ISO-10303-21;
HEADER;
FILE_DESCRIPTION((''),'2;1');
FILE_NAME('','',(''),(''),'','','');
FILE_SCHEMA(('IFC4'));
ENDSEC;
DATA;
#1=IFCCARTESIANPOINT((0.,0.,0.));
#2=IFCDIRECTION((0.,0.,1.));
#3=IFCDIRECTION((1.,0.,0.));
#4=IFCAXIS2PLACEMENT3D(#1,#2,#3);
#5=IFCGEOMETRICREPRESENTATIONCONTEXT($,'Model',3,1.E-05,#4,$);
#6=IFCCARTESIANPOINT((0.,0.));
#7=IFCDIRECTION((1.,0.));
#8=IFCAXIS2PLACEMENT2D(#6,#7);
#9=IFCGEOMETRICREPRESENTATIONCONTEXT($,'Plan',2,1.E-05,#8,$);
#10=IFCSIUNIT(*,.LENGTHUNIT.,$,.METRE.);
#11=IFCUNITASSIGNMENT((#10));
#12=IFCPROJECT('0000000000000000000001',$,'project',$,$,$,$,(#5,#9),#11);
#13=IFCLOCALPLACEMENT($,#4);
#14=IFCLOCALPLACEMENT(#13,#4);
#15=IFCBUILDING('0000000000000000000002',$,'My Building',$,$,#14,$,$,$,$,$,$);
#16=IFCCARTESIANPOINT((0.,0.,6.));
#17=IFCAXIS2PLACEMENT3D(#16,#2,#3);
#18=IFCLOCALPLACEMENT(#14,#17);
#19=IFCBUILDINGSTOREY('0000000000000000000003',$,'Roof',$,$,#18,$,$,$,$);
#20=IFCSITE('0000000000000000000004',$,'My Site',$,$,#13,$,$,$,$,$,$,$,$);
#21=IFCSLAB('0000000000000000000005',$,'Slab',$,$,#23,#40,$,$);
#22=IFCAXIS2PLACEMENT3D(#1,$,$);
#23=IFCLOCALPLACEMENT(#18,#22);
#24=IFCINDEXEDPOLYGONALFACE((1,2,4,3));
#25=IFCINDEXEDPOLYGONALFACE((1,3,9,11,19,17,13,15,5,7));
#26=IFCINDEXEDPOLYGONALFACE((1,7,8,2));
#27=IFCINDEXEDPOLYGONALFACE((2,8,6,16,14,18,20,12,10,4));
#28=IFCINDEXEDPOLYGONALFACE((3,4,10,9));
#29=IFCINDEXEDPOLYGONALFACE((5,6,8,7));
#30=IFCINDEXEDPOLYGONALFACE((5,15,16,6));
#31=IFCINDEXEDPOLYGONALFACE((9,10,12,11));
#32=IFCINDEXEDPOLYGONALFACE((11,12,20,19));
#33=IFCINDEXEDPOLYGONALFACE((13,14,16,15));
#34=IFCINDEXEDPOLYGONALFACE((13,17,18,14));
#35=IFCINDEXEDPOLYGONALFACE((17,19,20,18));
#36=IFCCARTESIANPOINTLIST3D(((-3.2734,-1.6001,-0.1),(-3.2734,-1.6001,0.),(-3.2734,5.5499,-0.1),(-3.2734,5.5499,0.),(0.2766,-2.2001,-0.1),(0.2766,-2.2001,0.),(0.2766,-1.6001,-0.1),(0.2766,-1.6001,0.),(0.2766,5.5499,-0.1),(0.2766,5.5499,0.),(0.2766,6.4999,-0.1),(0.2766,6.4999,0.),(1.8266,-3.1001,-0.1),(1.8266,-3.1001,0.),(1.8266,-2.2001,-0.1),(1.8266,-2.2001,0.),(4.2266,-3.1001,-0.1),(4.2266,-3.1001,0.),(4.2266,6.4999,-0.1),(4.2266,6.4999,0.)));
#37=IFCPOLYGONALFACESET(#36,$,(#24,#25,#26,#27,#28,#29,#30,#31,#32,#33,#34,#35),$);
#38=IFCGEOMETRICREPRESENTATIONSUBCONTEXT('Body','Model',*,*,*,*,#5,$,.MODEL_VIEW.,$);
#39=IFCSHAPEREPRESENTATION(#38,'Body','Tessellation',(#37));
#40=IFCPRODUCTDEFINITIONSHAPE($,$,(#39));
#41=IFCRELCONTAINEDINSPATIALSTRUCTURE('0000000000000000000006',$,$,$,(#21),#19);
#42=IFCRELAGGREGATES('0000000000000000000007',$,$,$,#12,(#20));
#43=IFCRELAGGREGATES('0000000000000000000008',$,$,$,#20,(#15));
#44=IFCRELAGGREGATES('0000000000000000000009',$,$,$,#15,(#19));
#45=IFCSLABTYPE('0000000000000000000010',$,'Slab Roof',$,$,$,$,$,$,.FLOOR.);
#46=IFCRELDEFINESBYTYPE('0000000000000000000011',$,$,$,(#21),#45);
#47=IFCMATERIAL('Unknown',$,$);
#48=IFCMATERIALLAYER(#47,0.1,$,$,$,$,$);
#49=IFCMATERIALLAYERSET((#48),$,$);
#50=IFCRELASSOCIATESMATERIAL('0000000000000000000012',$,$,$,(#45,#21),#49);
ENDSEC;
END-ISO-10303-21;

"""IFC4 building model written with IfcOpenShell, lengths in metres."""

from ifc_helpers import new_model, si_unit, frame, origin_with_axes, origin_2d_with_axis, place, context, subcontext, project, spatial, indexed_curve, outline, extrude, material, layer, layer_set, layer_usage, type_object, element, save


model = new_model("IFC4")

# Units and contexts
model_context = context("Model", 3, precision=1e-05, world=origin_with_axes())
plan_context = context("Plan", 2, precision=1e-05, world=origin_2d_with_axis())
body_context = subcontext(model_context, "Body", "Model", "MODEL_VIEW")
ifc_project = project(units=[si_unit("LENGTHUNIT", "METRE")], contexts=[model_context, plan_context])

# Site, building, storey
site_placement = place(None, origin_with_axes())
site = spatial("IfcSite", under=ifc_project, at=site_placement, Name="My Site")
building_placement = place(site_placement, origin_with_axes())
building = spatial("IfcBuilding", under=site, at=building_placement, Name="My Building")
storey_placement = place(building_placement, frame((0.0, 0.0, 6.0), z_axis=(0.0, 0.0, 1.0), x_axis=(1.0, 0.0, 0.0)))
storey = spatial("IfcBuildingStorey", under=building, at=storey_placement, Name="Roof")

# Slab
ifc_material = material(Name="Unknown")
ifc_layer = layer(ifc_material, 0.1)
ifc_layer_set = layer_set([ifc_layer])
ifc_layer_usage = layer_usage(ifc_layer_set, "AXIS3", "POSITIVE", -0.1)
slab_type = type_object("IfcSlabType", Name="Slab Roof", PredefinedType="FLOOR", material=ifc_layer_set)
slab_placement = place(storey_placement, frame((4.2266, -3.1001, 0.0), z_axis=(0.0, 0.0, 1.0), x_axis=(1.0, 0.0, 0.0)))
element("IfcSlab", 1, at=slab_placement, inside=storey, type_object=slab_type, material=ifc_layer_usage, Name="Slab", context=body_context, shape_type="SweptSolid", body=[
    extrude(outline(indexed_curve([(0.0, 0.0), (0.0, 9.6), (-3.95, 9.6), (-3.95, 8.65), (-7.5, 8.65), (-7.5, 1.5), (-3.95, 1.5), (-3.95, 0.9), (-2.4, 0.9), (-2.4, 0.0), (0.0, 0.0)])), frame((0.0, 0.0, -0.1), z_axis=(0.0, 0.0, 1.0), x_axis=(1.0, 0.0, 0.0)), (0.0, 0.0, 1.0), 0.1),
])

save(model, "model.ifc")
